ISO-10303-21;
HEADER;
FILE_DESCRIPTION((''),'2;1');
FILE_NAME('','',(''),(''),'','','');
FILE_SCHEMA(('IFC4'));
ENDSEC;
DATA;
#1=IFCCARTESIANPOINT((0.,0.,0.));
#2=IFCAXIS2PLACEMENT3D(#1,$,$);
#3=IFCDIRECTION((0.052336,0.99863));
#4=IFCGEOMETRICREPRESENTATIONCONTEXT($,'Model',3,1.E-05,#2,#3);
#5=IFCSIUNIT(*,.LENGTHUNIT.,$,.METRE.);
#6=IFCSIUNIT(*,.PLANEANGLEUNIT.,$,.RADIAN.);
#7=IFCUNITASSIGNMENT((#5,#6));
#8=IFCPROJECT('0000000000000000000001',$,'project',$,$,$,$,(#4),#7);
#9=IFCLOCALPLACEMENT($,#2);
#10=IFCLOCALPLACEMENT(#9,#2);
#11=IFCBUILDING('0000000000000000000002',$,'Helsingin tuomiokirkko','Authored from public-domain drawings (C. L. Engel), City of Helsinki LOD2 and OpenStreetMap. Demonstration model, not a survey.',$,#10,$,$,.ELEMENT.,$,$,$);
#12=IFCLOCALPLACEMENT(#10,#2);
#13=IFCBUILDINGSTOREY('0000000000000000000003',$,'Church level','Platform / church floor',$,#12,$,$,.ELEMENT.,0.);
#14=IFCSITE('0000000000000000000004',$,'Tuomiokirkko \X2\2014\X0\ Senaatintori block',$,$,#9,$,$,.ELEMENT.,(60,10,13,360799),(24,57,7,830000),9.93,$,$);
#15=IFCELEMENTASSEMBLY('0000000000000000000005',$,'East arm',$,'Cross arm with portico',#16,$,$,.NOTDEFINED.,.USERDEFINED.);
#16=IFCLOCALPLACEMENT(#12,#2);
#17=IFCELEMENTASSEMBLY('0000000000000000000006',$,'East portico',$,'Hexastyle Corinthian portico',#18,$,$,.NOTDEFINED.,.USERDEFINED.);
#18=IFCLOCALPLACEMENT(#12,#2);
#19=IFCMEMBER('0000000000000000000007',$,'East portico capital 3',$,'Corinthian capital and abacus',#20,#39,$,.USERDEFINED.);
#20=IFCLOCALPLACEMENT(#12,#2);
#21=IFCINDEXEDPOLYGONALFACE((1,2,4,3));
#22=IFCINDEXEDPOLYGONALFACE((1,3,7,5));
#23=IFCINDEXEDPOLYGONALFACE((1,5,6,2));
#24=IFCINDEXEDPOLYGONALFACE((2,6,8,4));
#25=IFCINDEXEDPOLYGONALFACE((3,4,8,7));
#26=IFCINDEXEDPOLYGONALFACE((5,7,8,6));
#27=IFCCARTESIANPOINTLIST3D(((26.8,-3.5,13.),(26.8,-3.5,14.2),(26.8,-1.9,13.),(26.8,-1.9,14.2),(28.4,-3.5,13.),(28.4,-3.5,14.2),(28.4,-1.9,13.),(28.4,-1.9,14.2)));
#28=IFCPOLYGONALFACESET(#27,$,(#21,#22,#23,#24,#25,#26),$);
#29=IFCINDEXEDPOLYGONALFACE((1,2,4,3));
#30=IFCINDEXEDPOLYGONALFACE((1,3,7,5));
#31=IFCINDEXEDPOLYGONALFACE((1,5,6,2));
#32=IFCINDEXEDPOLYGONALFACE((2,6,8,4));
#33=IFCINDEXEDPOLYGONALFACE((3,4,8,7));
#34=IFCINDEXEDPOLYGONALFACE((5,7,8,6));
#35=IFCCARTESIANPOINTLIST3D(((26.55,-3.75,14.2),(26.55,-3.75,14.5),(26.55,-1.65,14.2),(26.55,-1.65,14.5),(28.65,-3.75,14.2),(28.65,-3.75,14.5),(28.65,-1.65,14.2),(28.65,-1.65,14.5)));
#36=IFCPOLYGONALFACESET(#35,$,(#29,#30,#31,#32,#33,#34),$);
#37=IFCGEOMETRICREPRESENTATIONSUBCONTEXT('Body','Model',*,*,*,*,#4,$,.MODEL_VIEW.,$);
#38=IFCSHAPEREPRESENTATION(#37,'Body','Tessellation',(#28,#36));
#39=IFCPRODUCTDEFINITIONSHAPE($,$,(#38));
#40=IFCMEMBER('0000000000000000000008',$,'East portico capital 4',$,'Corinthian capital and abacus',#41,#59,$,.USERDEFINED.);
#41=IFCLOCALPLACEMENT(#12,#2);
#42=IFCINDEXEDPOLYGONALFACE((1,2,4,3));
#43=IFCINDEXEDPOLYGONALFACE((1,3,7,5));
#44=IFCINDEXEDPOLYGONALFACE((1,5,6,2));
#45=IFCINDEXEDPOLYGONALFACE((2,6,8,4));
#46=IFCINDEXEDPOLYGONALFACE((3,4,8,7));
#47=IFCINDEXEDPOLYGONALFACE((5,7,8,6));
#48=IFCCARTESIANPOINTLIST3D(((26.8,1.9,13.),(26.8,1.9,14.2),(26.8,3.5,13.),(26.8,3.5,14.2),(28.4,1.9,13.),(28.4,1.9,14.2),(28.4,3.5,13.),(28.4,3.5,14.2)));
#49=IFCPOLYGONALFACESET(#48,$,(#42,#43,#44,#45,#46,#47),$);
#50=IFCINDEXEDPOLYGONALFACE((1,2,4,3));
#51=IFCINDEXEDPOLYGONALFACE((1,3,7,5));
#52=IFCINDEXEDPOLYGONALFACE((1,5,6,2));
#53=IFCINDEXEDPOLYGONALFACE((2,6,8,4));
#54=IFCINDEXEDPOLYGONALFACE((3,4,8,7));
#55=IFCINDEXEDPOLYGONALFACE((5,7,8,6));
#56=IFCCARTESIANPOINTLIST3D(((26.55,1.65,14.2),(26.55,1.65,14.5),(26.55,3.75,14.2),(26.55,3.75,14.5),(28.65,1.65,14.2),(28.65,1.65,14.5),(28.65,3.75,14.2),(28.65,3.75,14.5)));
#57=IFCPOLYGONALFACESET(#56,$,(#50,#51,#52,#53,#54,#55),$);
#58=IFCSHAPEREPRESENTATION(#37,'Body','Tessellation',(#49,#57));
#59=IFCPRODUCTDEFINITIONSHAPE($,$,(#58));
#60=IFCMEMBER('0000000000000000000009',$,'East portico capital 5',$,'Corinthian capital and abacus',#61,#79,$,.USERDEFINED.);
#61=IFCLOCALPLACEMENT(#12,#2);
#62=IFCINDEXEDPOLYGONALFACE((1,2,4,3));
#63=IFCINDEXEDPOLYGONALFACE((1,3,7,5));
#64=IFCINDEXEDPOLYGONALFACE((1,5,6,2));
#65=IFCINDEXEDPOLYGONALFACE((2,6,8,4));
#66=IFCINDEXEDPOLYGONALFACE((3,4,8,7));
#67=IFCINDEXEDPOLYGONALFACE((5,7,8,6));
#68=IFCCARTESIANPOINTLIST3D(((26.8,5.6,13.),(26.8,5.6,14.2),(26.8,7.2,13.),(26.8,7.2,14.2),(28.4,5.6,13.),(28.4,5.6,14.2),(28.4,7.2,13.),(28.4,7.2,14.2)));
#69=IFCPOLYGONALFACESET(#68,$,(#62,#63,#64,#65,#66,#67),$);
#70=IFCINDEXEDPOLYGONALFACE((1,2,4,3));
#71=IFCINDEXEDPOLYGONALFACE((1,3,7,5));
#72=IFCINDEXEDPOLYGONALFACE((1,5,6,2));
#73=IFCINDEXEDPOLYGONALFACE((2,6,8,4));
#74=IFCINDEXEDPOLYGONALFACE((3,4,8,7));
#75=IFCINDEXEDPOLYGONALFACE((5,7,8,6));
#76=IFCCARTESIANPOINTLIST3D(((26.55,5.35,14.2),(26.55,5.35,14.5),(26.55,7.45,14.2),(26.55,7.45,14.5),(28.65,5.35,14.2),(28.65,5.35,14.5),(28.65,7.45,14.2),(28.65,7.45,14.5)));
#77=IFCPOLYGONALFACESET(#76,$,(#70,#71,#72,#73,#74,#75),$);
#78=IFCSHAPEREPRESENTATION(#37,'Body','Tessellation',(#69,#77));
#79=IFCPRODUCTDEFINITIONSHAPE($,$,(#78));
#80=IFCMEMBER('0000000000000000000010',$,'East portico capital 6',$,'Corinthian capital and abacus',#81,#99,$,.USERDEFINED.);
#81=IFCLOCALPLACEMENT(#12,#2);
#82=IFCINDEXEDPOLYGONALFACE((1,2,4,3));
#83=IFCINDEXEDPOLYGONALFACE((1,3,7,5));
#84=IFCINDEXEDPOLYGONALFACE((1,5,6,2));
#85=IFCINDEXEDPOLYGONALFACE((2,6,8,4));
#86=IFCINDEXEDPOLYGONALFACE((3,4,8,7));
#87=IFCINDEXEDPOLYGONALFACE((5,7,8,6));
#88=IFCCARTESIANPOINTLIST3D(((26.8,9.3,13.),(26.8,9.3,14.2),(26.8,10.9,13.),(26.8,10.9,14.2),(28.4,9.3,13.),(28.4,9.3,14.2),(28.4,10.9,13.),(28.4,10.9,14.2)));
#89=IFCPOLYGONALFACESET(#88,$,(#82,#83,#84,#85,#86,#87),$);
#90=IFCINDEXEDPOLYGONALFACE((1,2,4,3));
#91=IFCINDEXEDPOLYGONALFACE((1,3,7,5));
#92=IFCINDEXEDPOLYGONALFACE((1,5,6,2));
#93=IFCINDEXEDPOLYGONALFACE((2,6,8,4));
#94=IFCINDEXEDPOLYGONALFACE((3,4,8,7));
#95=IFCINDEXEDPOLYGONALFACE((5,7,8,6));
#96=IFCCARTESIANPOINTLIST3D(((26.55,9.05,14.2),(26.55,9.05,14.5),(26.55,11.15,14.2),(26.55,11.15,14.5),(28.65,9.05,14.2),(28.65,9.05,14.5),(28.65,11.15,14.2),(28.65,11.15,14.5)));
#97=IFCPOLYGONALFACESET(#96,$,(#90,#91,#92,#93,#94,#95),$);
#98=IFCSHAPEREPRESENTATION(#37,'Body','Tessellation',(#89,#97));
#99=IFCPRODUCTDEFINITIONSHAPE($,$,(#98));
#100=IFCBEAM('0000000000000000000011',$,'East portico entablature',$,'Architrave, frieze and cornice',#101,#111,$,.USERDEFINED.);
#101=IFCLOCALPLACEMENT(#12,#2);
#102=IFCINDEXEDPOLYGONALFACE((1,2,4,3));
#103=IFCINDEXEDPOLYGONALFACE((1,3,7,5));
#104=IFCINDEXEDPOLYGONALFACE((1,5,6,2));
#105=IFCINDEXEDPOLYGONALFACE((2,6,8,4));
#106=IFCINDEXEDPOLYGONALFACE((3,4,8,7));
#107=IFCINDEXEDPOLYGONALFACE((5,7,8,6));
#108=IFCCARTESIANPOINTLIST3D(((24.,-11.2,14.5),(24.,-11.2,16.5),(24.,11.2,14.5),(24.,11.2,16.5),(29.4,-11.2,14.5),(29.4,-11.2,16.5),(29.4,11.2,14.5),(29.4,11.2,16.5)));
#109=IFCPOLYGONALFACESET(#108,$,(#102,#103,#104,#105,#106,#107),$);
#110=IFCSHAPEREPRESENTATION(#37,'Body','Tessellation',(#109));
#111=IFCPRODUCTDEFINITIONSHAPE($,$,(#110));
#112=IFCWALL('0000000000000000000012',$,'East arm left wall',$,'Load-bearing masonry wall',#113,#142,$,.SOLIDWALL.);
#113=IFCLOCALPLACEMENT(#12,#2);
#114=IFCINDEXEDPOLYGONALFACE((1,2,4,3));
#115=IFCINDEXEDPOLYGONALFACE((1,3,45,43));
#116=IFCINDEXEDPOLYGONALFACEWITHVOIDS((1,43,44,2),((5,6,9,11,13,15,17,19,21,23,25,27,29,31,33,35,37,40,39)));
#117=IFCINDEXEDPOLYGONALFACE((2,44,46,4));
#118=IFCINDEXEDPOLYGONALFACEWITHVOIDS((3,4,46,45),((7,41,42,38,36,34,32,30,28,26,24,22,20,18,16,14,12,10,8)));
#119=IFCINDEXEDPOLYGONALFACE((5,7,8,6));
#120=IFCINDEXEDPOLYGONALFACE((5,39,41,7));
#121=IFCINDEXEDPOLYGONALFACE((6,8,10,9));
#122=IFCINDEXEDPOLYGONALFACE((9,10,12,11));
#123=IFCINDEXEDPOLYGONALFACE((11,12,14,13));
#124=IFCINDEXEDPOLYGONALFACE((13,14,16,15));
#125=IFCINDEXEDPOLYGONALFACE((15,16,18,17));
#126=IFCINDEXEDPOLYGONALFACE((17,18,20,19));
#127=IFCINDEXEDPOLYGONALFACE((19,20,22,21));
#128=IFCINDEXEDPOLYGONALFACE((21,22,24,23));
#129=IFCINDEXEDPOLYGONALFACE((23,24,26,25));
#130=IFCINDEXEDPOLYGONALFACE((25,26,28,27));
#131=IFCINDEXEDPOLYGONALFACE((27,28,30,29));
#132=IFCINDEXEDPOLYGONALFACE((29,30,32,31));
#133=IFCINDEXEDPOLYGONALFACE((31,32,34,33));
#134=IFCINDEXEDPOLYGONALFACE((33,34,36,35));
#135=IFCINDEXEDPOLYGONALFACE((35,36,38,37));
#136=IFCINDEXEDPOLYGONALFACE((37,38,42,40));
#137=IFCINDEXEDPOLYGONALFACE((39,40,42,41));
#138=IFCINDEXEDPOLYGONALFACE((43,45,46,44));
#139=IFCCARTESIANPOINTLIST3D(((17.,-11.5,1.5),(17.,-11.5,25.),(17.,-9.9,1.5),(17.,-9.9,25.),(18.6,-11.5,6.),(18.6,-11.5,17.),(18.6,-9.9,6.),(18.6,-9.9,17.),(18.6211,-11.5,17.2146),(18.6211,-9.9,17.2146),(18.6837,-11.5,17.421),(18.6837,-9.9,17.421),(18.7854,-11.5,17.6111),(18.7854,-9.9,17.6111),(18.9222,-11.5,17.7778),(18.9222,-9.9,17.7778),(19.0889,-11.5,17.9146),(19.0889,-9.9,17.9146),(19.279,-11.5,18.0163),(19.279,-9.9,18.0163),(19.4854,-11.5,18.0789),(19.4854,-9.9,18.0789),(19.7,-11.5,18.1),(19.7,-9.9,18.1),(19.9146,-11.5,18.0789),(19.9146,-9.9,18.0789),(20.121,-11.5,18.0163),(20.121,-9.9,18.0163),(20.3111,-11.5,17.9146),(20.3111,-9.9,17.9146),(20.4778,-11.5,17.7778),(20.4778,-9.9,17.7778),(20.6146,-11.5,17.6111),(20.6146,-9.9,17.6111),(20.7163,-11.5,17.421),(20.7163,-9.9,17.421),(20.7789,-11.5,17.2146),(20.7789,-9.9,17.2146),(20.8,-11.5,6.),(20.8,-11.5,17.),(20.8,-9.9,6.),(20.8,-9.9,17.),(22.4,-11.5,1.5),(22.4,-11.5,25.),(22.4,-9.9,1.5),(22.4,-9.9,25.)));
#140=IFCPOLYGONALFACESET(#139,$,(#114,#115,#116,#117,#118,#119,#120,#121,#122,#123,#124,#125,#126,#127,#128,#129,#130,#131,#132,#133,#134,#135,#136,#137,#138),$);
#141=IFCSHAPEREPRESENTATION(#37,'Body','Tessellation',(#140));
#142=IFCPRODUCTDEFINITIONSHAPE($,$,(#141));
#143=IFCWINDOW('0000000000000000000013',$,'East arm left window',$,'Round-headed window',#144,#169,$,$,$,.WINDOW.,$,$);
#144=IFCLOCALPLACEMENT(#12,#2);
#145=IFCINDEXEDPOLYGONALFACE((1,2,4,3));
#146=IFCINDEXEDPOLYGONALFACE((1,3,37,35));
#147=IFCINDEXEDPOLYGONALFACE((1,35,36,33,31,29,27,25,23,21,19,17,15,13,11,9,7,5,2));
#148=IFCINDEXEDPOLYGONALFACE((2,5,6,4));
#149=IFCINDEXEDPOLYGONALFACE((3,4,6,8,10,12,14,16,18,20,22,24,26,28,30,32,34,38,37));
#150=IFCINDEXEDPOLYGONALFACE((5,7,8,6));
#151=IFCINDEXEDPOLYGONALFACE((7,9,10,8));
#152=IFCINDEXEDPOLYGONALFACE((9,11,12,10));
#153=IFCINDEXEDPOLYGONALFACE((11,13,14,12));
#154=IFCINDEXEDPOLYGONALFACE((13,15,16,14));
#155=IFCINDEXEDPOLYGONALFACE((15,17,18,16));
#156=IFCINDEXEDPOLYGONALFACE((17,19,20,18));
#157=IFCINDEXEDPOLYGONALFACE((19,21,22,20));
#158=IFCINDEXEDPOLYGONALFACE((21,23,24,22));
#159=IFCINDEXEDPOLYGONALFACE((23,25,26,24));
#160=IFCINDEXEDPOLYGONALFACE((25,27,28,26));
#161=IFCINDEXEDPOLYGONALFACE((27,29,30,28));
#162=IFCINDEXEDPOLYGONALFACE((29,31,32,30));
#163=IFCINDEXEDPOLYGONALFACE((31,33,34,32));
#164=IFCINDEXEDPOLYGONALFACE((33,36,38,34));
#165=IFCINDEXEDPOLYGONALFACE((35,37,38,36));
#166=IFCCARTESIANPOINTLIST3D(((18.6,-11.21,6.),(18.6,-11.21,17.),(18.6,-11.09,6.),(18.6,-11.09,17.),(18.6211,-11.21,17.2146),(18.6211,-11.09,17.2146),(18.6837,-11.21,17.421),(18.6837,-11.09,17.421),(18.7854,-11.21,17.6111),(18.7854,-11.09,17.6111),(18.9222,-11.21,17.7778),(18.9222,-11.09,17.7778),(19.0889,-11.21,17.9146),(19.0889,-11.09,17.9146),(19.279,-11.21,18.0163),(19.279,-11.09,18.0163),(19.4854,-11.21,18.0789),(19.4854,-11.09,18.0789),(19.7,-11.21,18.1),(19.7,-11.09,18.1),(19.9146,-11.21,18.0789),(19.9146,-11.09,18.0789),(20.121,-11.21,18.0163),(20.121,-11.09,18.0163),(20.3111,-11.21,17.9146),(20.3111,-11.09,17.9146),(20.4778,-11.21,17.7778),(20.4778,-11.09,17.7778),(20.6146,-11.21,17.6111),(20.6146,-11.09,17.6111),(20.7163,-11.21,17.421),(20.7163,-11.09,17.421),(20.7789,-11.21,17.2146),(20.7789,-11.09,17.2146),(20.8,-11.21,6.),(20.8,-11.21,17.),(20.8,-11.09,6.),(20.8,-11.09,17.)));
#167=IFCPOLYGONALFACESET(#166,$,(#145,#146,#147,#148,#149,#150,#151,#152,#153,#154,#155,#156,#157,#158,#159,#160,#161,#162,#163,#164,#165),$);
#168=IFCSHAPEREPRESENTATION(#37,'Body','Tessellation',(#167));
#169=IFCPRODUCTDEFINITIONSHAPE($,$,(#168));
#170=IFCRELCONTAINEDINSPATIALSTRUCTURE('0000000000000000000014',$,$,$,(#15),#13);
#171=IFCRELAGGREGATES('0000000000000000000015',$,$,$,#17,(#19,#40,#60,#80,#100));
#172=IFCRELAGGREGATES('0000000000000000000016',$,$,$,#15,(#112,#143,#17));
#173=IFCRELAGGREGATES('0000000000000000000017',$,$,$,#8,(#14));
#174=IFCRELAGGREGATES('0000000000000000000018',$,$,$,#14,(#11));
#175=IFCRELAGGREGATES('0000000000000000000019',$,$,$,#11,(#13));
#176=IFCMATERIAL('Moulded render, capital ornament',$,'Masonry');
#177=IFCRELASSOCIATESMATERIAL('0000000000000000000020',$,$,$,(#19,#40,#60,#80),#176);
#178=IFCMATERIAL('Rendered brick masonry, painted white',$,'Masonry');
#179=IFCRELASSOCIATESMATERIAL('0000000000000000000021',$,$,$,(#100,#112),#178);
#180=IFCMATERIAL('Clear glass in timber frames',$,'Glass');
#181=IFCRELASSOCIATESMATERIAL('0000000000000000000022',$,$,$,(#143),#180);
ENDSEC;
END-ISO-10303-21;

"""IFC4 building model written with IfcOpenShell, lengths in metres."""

from ifc_helpers import new_model, si_unit, direction, frame, origin, origin_2d_with_axis, place, context, subcontext, project, spatial, polyline, rectangle, outline, extrude, material, element, fill, aggregate, save


model = new_model("IFC4")

# Units and contexts
model_context = context("Model", 3, precision=1e-05, world=origin(), true_north=direction((0.052336, 0.99863)))
body_context = subcontext(model_context, "Body", "Model", "MODEL_VIEW")
ifc_project = project(units=[si_unit("LENGTHUNIT", "METRE"), si_unit("PLANEANGLEUNIT", "RADIAN")], contexts=[model_context])

# Site, building, storey
site_placement = place(None, origin())
site = spatial("IfcSite", under=ifc_project, at=site_placement, Name="Tuomiokirkko — Senaatintori block", CompositionType="ELEMENT", RefLatitude=(60, 10, 13, 360799), RefLongitude=(24, 57, 7, 830000), RefElevation=9.93)
building_placement = place(site_placement, origin())
building = spatial("IfcBuilding", under=site, at=building_placement, Name="Helsingin tuomiokirkko", Description="Authored from public-domain drawings (C. L. Engel), City of Helsinki LOD2 and OpenStreetMap. Demonstration model, not a survey.", CompositionType="ELEMENT")
storey_placement = place(building_placement, origin())
storey = spatial("IfcBuildingStorey", under=building, at=storey_placement, Name="Church level", Description="Platform / church floor", CompositionType="ELEMENT", Elevation=0.0)

# Element assemblies
assembly_1_placement = place(building_placement, origin())
assembly_1 = element("IfcElementAssembly", 1, at=assembly_1_placement, inside=storey, Name="East arm", ObjectType="Cross arm with portico", AssemblyPlace="NOTDEFINED", PredefinedType="USERDEFINED")
ifc_material_1 = material(Name="Rendered brick masonry, painted white", Category="Masonry")
assembly_2_placement = place(building_placement, origin())
assembly_2 = element("IfcElementAssembly", 2, at=assembly_2_placement, Name="East portico", ObjectType="Hexastyle Corinthian portico", AssemblyPlace="NOTDEFINED", PredefinedType="USERDEFINED")

# Shared definitions
ifc_material_2 = material(Name="Moulded render, capital ornament", Category="Masonry")

# Members
member_1_placement = place(building_placement, origin())
member_1 = element("IfcMember", 3, at=member_1_placement, material=ifc_material_2, Name="East portico capital 3", ObjectType="Corinthian capital and abacus", PredefinedType="USERDEFINED", context=body_context, shape_type="SweptSolid", body=[
    extrude(rectangle(XDim=1.6, YDim=1.6, at=origin_2d_with_axis()), frame((27.6, -2.7, 13.0)), (0.0, 0.0, 1.0), 1.2),
    extrude(rectangle(XDim=2.1, YDim=2.1, at=origin_2d_with_axis()), frame((27.6, -2.7, 14.2)), (0.0, 0.0, 1.0), 0.3),
])
member_2_placement = place(building_placement, origin())
member_2 = element("IfcMember", 4, at=member_2_placement, material=ifc_material_2, Name="East portico capital 4", ObjectType="Corinthian capital and abacus", PredefinedType="USERDEFINED", context=body_context, shape_type="SweptSolid", body=[
    extrude(rectangle(XDim=1.6, YDim=1.6, at=origin_2d_with_axis()), frame((27.6, 2.7, 13.0)), (0.0, 0.0, 1.0), 1.2),
    extrude(rectangle(XDim=2.1, YDim=2.1, at=origin_2d_with_axis()), frame((27.6, 2.7, 14.2)), (0.0, 0.0, 1.0), 0.3),
])
member_3_placement = place(building_placement, origin())
member_3 = element("IfcMember", 5, at=member_3_placement, material=ifc_material_2, Name="East portico capital 5", ObjectType="Corinthian capital and abacus", PredefinedType="USERDEFINED", context=body_context, shape_type="SweptSolid", body=[
    extrude(rectangle(XDim=1.6, YDim=1.6, at=origin_2d_with_axis()), frame((27.6, 6.4, 13.0)), (0.0, 0.0, 1.0), 1.2),
    extrude(rectangle(XDim=2.1, YDim=2.1, at=origin_2d_with_axis()), frame((27.6, 6.4, 14.2)), (0.0, 0.0, 1.0), 0.3),
])
member_4_placement = place(building_placement, origin())
member_4 = element("IfcMember", 6, at=member_4_placement, material=ifc_material_2, Name="East portico capital 6", ObjectType="Corinthian capital and abacus", PredefinedType="USERDEFINED", context=body_context, shape_type="SweptSolid", body=[
    extrude(rectangle(XDim=1.6, YDim=1.6, at=origin_2d_with_axis()), frame((27.6, 10.1, 13.0)), (0.0, 0.0, 1.0), 1.2),
    extrude(rectangle(XDim=2.1, YDim=2.1, at=origin_2d_with_axis()), frame((27.6, 10.1, 14.2)), (0.0, 0.0, 1.0), 0.3),
])

# Beam
beam_1_placement = place(building_placement, origin())
beam_1 = element("IfcBeam", 7, at=beam_1_placement, material=ifc_material_1, Name="East portico entablature", ObjectType="Architrave, frieze and cornice", PredefinedType="USERDEFINED", context=body_context, shape_type="SweptSolid", body=[
    extrude(rectangle(XDim=5.4, YDim=22.4, at=origin_2d_with_axis()), frame((26.7, 0.0, 14.5)), (0.0, 0.0, 1.0), 2.0),
])
aggregate(assembly_2, [member_1, member_2, member_3, member_4, beam_1])

# Shared definitions
ifc_material_3 = material(Name="Clear glass in timber frames", Category="Glass")

# Wall, opening, window
wall_1_placement = place(building_placement, origin())
wall_1 = element("IfcWall", 8, at=wall_1_placement, material=ifc_material_1, Name="East arm left wall", ObjectType="Load-bearing masonry wall", PredefinedType="SOLIDWALL", context=body_context, shape_type="SweptSolid", body=[
    extrude(rectangle(XDim=5.4, YDim=1.6, at=origin_2d_with_axis()), frame((19.7, -10.7, 1.5)), (0.0, 0.0, 1.0), 23.5),
])
opening_1_placement = place(building_placement, origin())
opening_1 = element("IfcOpeningElement", 9, at=opening_1_placement, cuts=wall_1, PredefinedType="OPENING", context=body_context, shape_type="SweptSolid", body=[
    extrude(outline(polyline([(-1.1, 0.0), (1.1, 0.0), (1.1, 11.0), (1.0789, 11.2146), (1.0163, 11.421), (0.9146, 11.6111), (0.7778, 11.7778), (0.6111, 11.9146), (0.421, 12.0163), (0.2146, 12.0789), (0.0, 12.1), (-0.2146, 12.0789), (-0.421, 12.0163), (-0.6111, 11.9146), (-0.7778, 11.7778), (-0.9146, 11.6111), (-1.0163, 11.421), (-1.0789, 11.2146), (-1.1, 11.0), (-1.1, 0.0)])), frame((19.7, -9.7, 6.0), z_axis=(0.0, -1.0, 0.0), x_axis=(1.0, 0.0, 0.0)), (0.0, 0.0, 1.0), 2.0),
])
window_1_placement = place(building_placement, origin())
window_1 = element("IfcWindow", 10, at=window_1_placement, material=ifc_material_3, Name="East arm left window", ObjectType="Round-headed window", PredefinedType="WINDOW", context=body_context, shape_type="SweptSolid", body=[
    extrude(outline(polyline([(-1.1, 0.0), (1.1, 0.0), (1.1, 11.0), (1.0789, 11.2146), (1.0163, 11.421), (0.9146, 11.6111), (0.7778, 11.7778), (0.6111, 11.9146), (0.421, 12.0163), (0.2146, 12.0789), (0.0, 12.1), (-0.2146, 12.0789), (-0.421, 12.0163), (-0.6111, 11.9146), (-0.7778, 11.7778), (-0.9146, 11.6111), (-1.0163, 11.421), (-1.0789, 11.2146), (-1.1, 11.0), (-1.1, 0.0)])), frame((19.7, -11.09, 6.0), z_axis=(0.0, -1.0, 0.0), x_axis=(1.0, 0.0, 0.0)), (0.0, 0.0, 1.0), 0.12),
])
fill(opening_1, window_1)

aggregate(assembly_1, [wall_1, window_1, assembly_2])

save(model, "model.ifc")
